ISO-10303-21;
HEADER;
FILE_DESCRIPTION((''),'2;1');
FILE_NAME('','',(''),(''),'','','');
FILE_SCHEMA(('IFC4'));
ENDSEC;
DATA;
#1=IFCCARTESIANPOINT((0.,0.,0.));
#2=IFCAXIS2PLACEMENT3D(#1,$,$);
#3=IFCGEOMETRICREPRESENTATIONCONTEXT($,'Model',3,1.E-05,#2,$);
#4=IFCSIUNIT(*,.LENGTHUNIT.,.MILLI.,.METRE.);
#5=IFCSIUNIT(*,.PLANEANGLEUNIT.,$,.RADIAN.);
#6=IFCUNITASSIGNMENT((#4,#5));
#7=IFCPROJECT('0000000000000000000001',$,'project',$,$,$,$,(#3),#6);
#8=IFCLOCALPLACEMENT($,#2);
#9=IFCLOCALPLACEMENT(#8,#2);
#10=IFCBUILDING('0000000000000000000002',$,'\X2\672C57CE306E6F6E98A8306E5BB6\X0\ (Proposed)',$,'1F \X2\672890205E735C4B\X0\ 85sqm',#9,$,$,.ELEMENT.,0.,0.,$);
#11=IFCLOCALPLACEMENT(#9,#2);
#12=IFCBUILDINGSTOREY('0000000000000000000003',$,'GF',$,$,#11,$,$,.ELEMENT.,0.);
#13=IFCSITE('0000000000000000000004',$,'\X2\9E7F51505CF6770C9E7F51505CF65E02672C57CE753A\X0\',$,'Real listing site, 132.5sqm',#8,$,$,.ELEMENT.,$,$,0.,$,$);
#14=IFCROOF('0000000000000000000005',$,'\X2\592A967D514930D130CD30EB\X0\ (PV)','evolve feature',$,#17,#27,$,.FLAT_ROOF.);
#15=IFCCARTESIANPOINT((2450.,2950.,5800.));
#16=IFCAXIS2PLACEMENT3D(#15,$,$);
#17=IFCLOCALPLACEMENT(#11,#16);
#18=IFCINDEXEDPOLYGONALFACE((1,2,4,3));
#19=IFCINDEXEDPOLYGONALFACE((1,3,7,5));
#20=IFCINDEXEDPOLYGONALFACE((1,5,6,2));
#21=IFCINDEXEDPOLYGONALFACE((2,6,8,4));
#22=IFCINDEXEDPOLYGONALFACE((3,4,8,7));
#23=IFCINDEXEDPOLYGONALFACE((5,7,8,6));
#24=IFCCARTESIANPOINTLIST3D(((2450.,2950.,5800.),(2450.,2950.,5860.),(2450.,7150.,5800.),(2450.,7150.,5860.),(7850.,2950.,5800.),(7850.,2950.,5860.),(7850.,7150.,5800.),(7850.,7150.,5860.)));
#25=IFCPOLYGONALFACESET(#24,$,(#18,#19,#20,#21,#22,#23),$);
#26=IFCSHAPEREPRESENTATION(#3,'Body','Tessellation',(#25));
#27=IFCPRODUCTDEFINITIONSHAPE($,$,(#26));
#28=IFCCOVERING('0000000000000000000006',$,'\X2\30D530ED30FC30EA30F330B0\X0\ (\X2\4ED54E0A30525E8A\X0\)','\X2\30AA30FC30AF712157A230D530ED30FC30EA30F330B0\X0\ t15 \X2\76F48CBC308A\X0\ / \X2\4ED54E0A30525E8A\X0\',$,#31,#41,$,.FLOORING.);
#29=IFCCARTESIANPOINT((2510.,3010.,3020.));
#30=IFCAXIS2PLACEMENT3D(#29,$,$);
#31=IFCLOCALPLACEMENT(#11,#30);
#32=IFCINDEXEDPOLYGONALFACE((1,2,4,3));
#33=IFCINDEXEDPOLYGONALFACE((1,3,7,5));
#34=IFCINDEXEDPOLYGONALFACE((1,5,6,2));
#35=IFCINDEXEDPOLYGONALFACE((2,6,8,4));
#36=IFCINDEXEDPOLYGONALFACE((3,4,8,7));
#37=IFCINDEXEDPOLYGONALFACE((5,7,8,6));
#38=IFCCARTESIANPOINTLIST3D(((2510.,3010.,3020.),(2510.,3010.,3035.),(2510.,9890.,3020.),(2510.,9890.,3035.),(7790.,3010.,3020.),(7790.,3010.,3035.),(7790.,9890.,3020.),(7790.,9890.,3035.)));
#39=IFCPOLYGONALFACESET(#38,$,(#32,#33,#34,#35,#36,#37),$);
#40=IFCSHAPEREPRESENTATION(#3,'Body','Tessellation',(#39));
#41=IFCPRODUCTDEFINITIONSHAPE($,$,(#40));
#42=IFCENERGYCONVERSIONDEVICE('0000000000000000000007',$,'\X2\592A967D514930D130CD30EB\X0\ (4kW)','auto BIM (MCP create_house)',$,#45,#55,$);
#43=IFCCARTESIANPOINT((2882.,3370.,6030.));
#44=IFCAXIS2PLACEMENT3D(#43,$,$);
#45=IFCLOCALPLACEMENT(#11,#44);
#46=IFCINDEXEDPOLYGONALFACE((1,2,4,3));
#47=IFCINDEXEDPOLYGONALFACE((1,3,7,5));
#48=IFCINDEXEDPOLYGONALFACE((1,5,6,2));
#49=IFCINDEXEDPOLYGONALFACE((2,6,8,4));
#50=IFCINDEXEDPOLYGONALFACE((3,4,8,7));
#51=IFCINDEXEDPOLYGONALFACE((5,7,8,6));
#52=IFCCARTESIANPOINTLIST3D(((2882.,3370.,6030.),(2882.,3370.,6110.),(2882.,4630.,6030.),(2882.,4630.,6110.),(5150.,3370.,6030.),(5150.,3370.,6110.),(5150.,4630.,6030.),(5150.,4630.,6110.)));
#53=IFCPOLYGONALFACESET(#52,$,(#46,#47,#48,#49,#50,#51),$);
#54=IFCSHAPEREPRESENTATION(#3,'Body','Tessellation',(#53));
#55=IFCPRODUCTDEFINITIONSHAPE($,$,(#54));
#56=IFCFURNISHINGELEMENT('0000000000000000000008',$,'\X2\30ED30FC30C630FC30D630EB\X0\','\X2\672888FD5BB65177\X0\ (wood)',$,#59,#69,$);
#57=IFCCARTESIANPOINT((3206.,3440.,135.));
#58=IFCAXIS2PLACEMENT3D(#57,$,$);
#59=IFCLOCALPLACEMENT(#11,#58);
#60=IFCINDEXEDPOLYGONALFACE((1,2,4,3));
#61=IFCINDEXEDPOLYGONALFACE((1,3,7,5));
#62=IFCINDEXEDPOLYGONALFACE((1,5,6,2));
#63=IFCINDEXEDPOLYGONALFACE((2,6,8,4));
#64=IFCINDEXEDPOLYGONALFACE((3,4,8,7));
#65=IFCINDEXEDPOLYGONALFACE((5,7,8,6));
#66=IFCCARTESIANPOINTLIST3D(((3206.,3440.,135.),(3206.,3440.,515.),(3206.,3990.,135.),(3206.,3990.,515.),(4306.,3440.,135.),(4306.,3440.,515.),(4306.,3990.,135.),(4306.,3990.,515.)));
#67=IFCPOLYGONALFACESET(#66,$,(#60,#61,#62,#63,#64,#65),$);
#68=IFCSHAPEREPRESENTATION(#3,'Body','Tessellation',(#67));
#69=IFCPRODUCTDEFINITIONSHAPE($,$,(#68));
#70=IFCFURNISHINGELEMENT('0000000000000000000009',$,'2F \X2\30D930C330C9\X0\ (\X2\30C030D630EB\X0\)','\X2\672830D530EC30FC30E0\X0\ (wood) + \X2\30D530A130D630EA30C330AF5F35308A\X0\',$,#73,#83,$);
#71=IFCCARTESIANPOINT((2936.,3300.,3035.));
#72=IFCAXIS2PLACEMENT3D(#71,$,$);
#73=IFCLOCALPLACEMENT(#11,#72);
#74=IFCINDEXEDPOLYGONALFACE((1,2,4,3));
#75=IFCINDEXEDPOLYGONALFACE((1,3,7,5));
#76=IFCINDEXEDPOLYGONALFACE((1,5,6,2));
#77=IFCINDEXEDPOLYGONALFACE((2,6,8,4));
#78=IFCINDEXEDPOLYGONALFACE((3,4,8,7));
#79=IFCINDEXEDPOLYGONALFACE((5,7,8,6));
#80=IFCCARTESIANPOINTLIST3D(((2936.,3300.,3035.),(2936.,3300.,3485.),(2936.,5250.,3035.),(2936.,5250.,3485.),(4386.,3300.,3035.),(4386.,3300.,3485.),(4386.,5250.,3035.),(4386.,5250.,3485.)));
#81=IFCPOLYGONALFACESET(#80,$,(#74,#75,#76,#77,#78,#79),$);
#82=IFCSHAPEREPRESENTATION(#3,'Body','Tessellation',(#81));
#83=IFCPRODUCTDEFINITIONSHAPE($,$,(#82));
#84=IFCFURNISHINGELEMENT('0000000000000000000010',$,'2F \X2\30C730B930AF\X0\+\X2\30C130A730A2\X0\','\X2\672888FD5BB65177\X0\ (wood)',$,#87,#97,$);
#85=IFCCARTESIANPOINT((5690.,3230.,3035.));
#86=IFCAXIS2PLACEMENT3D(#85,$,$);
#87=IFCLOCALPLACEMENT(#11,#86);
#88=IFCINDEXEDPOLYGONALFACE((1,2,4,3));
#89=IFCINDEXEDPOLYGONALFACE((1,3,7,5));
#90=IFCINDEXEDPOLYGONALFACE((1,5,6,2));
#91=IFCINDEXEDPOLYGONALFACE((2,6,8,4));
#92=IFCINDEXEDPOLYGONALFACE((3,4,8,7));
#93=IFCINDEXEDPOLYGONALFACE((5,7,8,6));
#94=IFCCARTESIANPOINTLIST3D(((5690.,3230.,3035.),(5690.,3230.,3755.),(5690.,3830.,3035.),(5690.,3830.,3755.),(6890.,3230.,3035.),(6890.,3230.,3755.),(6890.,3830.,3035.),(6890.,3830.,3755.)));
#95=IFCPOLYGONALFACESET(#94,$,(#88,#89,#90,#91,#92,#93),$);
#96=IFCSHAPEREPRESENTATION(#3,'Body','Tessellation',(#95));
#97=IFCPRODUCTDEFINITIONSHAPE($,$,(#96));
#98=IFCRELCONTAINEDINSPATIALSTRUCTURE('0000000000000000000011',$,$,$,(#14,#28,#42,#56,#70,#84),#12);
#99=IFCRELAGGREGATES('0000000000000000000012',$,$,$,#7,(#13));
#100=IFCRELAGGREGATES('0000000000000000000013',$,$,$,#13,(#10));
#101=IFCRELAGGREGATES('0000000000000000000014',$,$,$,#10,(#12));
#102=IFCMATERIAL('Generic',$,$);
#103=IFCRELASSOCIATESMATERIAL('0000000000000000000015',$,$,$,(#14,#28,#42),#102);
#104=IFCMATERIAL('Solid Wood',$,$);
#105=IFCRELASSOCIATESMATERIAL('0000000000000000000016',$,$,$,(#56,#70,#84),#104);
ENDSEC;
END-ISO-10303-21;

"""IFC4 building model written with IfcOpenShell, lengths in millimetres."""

from ifc_helpers import new_model, si_unit, frame, frame_2d, origin, place, context, project, spatial, rectangle, extrude, material, element, save


model = new_model("IFC4")

# Units and contexts
model_context = context("Model", 3, precision=1e-05, world=origin())
ifc_project = project(units=[si_unit("LENGTHUNIT", "METRE", prefix="MILLI"), si_unit("PLANEANGLEUNIT", "RADIAN")], contexts=[model_context])

# Site, building, storey
site_placement = place(None, origin())
site = spatial("IfcSite", under=ifc_project, at=site_placement, Name="鹿児島県鹿児島市本城町", ObjectType="Real listing site, 132.5sqm", CompositionType="ELEMENT", RefElevation=0.0)
building_placement = place(site_placement, origin())
building = spatial("IfcBuilding", under=site, at=building_placement, Name="本城の潮風の家 (Proposed)", ObjectType="1F 木造平屋 85sqm", CompositionType="ELEMENT", ElevationOfRefHeight=0.0, ElevationOfTerrain=0.0)
storey_placement = place(building_placement, origin())
storey = spatial("IfcBuildingStorey", under=building, at=storey_placement, Name="GF", CompositionType="ELEMENT", Elevation=0.0)

# Shared definitions
ifc_material_1 = material(Name="Solid Wood")

# Shared definitions
ifc_material_2 = material(Name="Generic")

# Roof
roof_1_placement = place(storey_placement, frame((2450.0, 2950.0, 5800.0)))
element("IfcRoof", 1, at=roof_1_placement, inside=storey, material=ifc_material_2, Name="太陽光パネル (PV)", Description="evolve feature", PredefinedType="FLAT_ROOF", context=model_context, shape_type="SweptSolid", body=[
    extrude(rectangle(XDim=5400.0, YDim=4200.0, at=frame_2d((2700.0, 2100.0))), frame((2450.0, 2950.0, 5800.0)), (0.0, 0.0, 1.0), 60.0),
])

# Covering
covering_placement = place(storey_placement, frame((2510.0, 3010.0, 3020.0)))
element("IfcCovering", 2, at=covering_placement, inside=storey, material=ifc_material_2, Name="フローリング (仕上げ床)", Description="オーク無垢フローリング t15 直貼り / 仕上げ床", PredefinedType="FLOORING", context=model_context, shape_type="SweptSolid", body=[
    extrude(rectangle(XDim=5280.0, YDim=6880.0, at=frame_2d((2640.0, 3440.0))), frame((2510.0, 3010.0, 3020.0)), (0.0, 0.0, 1.0), 15.0),
])

# Energy conversion device
energy_conversion_device_placement = place(storey_placement, frame((2882.0, 3370.0, 6030.0)))
element("IfcEnergyConversionDevice", 3, at=energy_conversion_device_placement, inside=storey, material=ifc_material_2, Name="太陽光パネル (4kW)", Description="auto BIM (MCP create_house)", context=model_context, shape_type="SweptSolid", body=[
    extrude(rectangle(XDim=2268.0, YDim=1260.0, at=frame_2d((1134.0, 630.0))), frame((2882.0, 3370.0, 6030.0)), (0.0, 0.0, 1.0), 80.0),
])

# Furnishing elements
furnishing_1_placement = place(storey_placement, frame((3206.0, 3440.0, 135.0)))
element("IfcFurnishingElement", 4, at=furnishing_1_placement, inside=storey, material=ifc_material_1, Name="ローテーブル", Description="木製家具 (wood)", context=model_context, shape_type="SweptSolid", body=[
    extrude(rectangle(XDim=1100.0, YDim=550.0, at=frame_2d((550.0, 275.0))), frame((3206.0, 3440.0, 135.0)), (0.0, 0.0, 1.0), 380.0),
])
furnishing_2_placement = place(storey_placement, frame((2936.0, 3300.0, 3035.0)))
element("IfcFurnishingElement", 5, at=furnishing_2_placement, inside=storey, material=ifc_material_1, Name="2F ベッド (ダブル)", Description="木フレーム (wood) + ファブリック張り", context=model_context, shape_type="SweptSolid", body=[
    extrude(rectangle(XDim=1450.0, YDim=1950.0, at=frame_2d((725.0, 975.0))), frame((2936.0, 3300.0, 3035.0)), (0.0, 0.0, 1.0), 450.0),
])
furnishing_3_placement = place(storey_placement, frame((5690.0, 3230.0, 3035.0)))
element("IfcFurnishingElement", 6, at=furnishing_3_placement, inside=storey, material=ifc_material_1, Name="2F デスク+チェア", Description="木製家具 (wood)", context=model_context, shape_type="SweptSolid", body=[
    extrude(rectangle(XDim=1200.0, YDim=600.0, at=frame_2d((600.0, 300.0))), frame((5690.0, 3230.0, 3035.0)), (0.0, 0.0, 1.0), 720.0),
])

save(model, "model.ifc")
